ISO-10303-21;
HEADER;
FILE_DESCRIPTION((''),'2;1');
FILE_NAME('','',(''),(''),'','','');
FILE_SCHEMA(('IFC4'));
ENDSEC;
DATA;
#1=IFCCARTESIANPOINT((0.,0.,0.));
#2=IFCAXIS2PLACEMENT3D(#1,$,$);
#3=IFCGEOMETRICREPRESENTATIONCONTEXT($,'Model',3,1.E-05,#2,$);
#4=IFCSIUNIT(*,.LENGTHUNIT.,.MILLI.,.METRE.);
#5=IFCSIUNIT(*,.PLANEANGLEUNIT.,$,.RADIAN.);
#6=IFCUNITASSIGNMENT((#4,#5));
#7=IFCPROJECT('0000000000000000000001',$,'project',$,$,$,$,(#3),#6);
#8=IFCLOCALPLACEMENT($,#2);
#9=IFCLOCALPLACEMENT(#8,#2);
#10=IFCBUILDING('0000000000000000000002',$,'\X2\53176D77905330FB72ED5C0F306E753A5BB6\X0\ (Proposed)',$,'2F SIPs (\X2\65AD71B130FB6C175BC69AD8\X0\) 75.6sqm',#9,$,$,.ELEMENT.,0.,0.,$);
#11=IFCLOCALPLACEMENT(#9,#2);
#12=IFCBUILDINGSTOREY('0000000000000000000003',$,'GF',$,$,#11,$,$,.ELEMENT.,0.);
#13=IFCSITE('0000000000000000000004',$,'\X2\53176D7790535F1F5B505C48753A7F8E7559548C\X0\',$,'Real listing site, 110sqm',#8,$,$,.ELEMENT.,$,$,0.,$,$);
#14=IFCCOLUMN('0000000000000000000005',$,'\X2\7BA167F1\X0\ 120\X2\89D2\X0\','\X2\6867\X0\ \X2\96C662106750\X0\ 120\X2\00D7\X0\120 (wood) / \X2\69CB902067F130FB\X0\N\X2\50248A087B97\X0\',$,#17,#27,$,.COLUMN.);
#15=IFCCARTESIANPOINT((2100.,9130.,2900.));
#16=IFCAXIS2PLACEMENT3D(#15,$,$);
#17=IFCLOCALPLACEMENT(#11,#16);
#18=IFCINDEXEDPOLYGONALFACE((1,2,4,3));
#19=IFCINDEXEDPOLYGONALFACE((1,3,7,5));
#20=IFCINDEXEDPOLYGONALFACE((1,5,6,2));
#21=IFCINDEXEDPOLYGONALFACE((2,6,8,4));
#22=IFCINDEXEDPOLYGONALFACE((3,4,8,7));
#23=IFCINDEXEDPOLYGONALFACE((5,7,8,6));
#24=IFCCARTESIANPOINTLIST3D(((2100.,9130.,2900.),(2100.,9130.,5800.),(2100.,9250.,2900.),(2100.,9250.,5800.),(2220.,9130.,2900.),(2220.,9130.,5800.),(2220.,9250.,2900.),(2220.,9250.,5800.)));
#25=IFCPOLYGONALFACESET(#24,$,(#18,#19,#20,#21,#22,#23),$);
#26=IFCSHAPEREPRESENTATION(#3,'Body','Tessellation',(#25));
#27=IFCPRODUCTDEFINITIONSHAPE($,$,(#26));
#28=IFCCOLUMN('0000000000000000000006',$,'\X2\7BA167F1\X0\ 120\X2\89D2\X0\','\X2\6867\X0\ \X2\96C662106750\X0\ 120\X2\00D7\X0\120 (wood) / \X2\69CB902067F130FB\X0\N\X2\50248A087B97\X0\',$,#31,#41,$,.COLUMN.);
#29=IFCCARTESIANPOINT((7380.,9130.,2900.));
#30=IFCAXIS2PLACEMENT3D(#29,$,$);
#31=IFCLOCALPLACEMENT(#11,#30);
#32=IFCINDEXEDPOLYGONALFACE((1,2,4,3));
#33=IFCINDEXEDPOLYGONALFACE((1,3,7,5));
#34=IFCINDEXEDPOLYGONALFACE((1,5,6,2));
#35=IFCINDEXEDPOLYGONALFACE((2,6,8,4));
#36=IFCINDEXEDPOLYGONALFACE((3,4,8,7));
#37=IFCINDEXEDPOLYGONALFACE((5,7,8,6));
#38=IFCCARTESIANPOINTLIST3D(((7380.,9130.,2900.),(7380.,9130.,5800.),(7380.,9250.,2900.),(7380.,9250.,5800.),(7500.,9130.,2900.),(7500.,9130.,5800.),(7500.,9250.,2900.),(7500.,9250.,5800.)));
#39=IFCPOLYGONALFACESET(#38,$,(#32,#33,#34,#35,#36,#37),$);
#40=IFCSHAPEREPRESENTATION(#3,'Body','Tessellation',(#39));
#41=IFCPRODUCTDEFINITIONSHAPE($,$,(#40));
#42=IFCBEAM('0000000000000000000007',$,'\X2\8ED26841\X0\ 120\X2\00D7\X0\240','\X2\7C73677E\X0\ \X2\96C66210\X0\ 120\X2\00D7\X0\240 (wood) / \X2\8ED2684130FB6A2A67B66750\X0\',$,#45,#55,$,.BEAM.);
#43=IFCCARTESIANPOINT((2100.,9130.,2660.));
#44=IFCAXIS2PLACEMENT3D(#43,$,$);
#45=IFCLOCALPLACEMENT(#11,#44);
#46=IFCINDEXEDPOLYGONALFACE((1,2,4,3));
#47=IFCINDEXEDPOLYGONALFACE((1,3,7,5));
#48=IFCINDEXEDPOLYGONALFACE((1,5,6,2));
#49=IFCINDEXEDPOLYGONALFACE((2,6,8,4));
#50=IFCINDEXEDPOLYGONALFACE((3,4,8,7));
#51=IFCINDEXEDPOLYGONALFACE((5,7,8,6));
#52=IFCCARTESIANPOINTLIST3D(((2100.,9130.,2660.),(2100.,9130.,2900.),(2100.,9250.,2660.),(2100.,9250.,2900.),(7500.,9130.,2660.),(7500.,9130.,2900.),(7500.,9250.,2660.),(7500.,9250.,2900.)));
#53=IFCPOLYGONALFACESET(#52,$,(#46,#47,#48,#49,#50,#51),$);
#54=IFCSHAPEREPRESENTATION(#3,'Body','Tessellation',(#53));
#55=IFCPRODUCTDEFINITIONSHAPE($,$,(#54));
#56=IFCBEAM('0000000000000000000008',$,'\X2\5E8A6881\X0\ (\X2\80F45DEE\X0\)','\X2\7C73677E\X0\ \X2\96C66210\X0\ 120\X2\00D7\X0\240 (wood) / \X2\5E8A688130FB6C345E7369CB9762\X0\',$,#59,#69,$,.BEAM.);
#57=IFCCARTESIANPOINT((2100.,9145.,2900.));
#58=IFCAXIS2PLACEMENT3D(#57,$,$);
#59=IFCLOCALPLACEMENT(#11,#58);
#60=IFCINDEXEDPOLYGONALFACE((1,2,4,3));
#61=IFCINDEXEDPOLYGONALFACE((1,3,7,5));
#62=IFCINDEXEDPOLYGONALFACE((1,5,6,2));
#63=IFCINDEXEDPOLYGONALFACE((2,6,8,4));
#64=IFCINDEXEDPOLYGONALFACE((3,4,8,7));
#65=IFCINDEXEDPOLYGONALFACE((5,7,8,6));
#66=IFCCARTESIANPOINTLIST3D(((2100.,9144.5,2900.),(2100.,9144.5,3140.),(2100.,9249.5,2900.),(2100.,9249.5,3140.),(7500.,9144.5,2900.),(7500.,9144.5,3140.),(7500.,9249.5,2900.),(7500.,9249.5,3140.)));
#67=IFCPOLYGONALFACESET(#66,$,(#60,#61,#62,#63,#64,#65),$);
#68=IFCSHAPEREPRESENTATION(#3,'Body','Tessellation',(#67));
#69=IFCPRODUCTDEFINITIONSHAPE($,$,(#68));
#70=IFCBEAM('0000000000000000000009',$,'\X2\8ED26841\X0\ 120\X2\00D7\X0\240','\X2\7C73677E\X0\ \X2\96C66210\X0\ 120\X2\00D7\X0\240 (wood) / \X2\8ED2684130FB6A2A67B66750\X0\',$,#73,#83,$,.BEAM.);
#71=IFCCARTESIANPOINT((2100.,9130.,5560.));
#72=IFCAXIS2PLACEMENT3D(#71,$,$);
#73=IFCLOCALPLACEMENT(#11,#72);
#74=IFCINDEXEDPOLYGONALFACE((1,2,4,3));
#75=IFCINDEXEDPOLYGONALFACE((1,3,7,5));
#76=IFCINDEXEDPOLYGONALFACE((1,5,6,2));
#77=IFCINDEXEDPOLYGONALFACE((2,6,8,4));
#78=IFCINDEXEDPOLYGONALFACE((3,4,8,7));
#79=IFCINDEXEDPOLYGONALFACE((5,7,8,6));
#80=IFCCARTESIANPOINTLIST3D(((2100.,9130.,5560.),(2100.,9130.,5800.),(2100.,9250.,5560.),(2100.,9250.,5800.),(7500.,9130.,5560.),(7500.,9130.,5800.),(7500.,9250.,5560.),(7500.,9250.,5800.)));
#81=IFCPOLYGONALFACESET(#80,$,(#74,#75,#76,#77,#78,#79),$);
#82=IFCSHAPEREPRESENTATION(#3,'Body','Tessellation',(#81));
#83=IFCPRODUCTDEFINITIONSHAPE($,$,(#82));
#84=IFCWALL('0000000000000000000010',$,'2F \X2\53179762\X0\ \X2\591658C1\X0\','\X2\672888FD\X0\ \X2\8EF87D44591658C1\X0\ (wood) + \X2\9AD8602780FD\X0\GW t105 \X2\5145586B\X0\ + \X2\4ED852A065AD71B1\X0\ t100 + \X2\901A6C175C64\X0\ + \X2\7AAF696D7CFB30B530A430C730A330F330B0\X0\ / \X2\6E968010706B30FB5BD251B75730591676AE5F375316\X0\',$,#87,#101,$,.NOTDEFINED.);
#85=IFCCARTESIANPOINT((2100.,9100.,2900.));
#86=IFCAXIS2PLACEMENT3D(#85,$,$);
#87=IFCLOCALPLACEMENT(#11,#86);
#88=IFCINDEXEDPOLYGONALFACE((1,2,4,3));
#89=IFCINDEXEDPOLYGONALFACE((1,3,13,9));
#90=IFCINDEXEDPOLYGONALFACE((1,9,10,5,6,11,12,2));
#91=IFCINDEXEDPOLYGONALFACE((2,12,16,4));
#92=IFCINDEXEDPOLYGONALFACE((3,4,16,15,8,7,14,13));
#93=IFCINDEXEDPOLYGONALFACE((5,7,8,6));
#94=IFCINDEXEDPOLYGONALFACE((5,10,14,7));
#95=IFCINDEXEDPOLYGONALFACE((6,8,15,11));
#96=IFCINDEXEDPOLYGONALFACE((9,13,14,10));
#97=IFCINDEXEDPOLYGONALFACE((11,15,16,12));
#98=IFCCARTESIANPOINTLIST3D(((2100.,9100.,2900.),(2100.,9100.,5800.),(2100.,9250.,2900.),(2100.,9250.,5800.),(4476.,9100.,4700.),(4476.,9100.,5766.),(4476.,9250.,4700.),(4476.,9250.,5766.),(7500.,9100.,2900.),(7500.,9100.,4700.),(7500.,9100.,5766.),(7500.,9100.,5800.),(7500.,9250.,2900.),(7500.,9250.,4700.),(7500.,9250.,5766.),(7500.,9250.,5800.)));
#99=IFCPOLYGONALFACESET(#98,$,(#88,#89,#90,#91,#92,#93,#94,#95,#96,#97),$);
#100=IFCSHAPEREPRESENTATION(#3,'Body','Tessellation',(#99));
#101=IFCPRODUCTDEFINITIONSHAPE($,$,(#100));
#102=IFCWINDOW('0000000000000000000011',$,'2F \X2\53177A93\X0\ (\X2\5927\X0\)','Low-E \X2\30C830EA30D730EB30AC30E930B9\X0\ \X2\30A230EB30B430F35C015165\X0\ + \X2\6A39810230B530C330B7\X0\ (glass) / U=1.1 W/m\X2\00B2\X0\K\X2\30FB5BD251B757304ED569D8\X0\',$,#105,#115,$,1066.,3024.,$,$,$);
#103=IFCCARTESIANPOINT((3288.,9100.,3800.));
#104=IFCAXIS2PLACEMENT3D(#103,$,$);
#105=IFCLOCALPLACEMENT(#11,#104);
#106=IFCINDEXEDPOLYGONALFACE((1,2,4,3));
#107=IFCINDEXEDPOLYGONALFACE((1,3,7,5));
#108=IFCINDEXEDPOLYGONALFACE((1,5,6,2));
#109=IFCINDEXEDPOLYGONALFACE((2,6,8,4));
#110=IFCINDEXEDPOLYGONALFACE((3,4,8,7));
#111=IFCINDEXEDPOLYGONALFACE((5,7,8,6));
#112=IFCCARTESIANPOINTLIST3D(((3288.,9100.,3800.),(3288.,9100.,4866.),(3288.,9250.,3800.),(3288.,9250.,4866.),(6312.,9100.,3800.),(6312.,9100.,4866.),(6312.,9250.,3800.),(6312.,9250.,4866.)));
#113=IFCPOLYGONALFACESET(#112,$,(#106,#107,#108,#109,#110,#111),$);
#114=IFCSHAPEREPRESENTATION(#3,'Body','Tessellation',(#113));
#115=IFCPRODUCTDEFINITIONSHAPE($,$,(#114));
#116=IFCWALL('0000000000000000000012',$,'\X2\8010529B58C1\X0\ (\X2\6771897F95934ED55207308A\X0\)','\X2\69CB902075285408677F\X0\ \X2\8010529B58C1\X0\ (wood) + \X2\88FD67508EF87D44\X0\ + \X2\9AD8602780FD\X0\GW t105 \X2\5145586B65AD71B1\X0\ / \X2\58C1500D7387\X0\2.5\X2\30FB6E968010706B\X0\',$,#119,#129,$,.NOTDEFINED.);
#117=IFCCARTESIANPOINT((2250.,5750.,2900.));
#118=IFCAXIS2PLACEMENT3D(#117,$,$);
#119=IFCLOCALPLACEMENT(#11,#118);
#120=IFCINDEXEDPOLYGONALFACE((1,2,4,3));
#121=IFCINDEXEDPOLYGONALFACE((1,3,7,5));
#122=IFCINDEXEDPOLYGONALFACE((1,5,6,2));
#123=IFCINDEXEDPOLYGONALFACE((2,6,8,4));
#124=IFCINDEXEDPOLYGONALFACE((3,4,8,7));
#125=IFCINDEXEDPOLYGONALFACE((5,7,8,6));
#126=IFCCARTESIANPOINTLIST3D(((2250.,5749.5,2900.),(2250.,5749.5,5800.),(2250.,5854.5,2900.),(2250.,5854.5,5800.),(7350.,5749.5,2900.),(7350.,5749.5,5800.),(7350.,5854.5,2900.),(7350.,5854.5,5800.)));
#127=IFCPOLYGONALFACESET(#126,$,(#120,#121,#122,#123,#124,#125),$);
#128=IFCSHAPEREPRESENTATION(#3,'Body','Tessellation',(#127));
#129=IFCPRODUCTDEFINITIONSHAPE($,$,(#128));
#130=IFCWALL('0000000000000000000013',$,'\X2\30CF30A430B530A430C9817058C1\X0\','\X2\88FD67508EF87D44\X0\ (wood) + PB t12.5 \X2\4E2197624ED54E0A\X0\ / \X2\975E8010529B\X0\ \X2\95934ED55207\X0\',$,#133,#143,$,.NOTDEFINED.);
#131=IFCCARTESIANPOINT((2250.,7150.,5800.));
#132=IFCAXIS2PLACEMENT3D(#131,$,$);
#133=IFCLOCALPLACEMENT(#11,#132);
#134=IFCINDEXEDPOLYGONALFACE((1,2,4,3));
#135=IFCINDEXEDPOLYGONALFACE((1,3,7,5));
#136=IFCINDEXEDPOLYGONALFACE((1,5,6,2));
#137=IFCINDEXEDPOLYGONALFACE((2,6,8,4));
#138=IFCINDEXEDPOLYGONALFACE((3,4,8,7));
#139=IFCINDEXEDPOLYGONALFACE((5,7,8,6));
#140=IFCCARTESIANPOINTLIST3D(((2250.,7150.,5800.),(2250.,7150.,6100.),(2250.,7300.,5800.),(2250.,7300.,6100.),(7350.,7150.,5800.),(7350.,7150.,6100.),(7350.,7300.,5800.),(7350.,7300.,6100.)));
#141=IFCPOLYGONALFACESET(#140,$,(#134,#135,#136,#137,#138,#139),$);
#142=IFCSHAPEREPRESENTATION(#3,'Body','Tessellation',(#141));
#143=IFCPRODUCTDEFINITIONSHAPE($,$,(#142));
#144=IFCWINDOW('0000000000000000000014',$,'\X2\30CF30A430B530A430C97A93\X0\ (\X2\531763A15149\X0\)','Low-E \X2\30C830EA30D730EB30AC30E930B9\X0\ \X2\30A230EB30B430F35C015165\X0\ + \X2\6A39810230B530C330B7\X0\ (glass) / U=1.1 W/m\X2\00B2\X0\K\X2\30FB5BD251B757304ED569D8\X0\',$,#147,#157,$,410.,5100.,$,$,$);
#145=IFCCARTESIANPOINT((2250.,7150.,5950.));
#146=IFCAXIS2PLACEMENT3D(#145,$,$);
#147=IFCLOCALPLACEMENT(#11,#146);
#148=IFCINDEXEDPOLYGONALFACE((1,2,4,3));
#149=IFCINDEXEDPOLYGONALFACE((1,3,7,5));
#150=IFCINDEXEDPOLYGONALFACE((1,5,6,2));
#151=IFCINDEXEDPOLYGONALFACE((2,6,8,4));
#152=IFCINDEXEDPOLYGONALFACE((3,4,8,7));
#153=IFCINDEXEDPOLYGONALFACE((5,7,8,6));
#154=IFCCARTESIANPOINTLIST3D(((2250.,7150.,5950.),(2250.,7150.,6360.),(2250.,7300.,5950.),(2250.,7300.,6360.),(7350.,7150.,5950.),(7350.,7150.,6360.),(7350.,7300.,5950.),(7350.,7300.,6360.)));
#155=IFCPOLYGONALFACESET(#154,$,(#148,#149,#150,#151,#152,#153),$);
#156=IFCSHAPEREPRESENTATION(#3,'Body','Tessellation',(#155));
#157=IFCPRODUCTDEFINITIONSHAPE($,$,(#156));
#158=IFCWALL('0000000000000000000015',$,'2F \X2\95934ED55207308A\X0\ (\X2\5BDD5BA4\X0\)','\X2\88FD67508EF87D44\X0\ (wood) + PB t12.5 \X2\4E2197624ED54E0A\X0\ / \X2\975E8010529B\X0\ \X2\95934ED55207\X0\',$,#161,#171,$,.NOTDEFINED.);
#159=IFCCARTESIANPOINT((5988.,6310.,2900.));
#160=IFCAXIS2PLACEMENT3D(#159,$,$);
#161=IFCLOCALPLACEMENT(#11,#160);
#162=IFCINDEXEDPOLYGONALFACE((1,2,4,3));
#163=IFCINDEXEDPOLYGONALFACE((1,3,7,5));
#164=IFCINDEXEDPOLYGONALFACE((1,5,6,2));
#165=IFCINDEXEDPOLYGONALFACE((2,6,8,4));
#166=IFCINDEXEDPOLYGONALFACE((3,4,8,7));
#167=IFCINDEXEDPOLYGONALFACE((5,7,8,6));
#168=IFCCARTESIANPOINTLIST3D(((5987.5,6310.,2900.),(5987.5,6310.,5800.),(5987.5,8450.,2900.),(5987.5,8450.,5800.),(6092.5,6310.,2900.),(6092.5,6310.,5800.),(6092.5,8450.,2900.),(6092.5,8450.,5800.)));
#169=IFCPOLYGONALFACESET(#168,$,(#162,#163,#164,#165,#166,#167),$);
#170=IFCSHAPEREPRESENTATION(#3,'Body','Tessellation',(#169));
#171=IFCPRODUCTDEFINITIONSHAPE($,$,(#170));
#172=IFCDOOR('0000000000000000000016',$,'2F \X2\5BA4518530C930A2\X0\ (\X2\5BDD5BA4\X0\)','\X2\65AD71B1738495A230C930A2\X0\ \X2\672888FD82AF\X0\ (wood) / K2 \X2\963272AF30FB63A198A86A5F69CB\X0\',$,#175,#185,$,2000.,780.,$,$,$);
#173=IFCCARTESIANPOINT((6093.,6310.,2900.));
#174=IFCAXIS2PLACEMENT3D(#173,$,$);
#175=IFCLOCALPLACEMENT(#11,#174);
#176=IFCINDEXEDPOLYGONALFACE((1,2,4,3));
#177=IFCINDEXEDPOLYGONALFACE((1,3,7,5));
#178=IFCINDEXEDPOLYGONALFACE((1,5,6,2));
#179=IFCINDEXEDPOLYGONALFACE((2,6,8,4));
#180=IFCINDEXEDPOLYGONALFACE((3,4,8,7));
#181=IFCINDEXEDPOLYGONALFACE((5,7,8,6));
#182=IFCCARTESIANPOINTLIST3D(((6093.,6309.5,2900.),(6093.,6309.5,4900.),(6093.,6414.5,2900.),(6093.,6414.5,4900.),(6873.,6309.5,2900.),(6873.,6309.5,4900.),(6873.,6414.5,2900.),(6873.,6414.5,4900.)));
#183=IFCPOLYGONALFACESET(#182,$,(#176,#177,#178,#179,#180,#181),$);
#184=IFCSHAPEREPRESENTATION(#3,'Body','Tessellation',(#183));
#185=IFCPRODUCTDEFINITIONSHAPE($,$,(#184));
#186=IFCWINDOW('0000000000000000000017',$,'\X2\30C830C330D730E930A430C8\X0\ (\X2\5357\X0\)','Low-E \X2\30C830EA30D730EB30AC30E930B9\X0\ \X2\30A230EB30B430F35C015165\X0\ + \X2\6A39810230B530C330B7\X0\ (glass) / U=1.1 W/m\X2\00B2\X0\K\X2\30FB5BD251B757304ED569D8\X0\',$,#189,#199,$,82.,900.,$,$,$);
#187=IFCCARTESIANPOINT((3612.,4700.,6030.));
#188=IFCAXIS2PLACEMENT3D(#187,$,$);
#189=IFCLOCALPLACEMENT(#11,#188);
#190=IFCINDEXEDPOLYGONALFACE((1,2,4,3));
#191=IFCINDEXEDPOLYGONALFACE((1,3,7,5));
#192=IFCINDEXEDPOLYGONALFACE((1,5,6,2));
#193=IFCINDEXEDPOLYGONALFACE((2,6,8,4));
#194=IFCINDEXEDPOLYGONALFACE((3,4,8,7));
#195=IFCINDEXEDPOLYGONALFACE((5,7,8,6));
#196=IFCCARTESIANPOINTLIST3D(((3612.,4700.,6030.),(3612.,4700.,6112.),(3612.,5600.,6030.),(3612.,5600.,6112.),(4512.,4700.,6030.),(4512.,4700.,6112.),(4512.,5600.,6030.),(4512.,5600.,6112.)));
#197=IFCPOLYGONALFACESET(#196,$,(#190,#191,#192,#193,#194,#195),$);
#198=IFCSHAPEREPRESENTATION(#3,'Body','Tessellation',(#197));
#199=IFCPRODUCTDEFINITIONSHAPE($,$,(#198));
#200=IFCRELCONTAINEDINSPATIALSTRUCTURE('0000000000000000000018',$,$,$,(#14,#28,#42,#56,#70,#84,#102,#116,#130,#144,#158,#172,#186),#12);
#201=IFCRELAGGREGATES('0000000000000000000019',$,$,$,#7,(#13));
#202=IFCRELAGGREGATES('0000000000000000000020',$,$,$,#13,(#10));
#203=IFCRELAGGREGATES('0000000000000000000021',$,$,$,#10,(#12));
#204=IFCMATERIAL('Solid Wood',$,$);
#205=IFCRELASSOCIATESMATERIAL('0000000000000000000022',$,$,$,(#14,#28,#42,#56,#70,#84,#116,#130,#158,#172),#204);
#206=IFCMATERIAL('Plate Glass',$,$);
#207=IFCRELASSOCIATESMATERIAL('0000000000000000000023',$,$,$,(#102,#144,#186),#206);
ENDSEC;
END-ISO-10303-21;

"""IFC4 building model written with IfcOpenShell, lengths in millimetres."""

from ifc_helpers import new_model, si_unit, frame, frame_2d, origin, place, context, project, spatial, rectangle, extrude, material, element, fill, save


model = new_model("IFC4")

# Units and contexts
model_context = context("Model", 3, precision=1e-05, world=origin())
ifc_project = project(units=[si_unit("LENGTHUNIT", "METRE", prefix="MILLI"), si_unit("PLANEANGLEUNIT", "RADIAN")], contexts=[model_context])

# Site, building, storey
site_placement = place(None, origin())
site = spatial("IfcSite", under=ifc_project, at=site_placement, Name="北海道弟子屈町美留和", ObjectType="Real listing site, 110sqm", CompositionType="ELEMENT", RefElevation=0.0)
building_placement = place(site_placement, origin())
building = spatial("IfcBuilding", under=site, at=building_placement, Name="北海道・狭小の町家 (Proposed)", ObjectType="2F SIPs (断熱・気密高) 75.6sqm", CompositionType="ELEMENT", ElevationOfRefHeight=0.0, ElevationOfTerrain=0.0)
storey_placement = place(building_placement, origin())
storey = spatial("IfcBuildingStorey", under=building, at=storey_placement, Name="GF", CompositionType="ELEMENT", Elevation=0.0)

# Columns
ifc_material_1 = material(Name="Solid Wood")
column_1_placement = place(storey_placement, frame((2100.0, 9130.0, 2900.0)))
element("IfcColumn", 1, at=column_1_placement, inside=storey, material=ifc_material_1, Name="管柱 120角", Description="桧 集成材 120×120 (wood) / 構造柱・N値計算", PredefinedType="COLUMN", context=model_context, shape_type="SweptSolid", body=[
    extrude(rectangle(XDim=120.0, YDim=120.0, at=frame_2d((60.0, 60.0))), frame((2100.0, 9130.0, 2900.0)), (0.0, 0.0, 1.0), 2900.0),
])
column_2_placement = place(storey_placement, frame((7380.0, 9130.0, 2900.0)))
element("IfcColumn", 2, at=column_2_placement, inside=storey, material=ifc_material_1, Name="管柱 120角", Description="桧 集成材 120×120 (wood) / 構造柱・N値計算", PredefinedType="COLUMN", context=model_context, shape_type="SweptSolid", body=[
    extrude(rectangle(XDim=120.0, YDim=120.0, at=frame_2d((60.0, 60.0))), frame((7380.0, 9130.0, 2900.0)), (0.0, 0.0, 1.0), 2900.0),
])

# Beams
beam_1_placement = place(storey_placement, frame((2100.0, 9130.0, 2660.0)))
element("IfcBeam", 3, at=beam_1_placement, inside=storey, material=ifc_material_1, Name="軒桁 120×240", Description="米松 集成 120×240 (wood) / 軒桁・横架材", PredefinedType="BEAM", context=model_context, shape_type="SweptSolid", body=[
    extrude(rectangle(XDim=5400.0, YDim=120.0, at=frame_2d((2700.0, 60.0))), frame((2100.0, 9130.0, 2660.0)), (0.0, 0.0, 1.0), 240.0),
])
beam_2_placement = place(storey_placement, frame((2100.0, 9145.0, 2900.0)))
element("IfcBeam", 4, at=beam_2_placement, inside=storey, material=ifc_material_1, Name="床梁 (胴差)", Description="米松 集成 120×240 (wood) / 床梁・水平構面", PredefinedType="BEAM", context=model_context, shape_type="SweptSolid", body=[
    extrude(rectangle(XDim=5400.0, YDim=105.0, at=frame_2d((2700.0, 52.0))), frame((2100.0, 9145.0, 2900.0)), (0.0, 0.0, 1.0), 240.0),
])
beam_3_placement = place(storey_placement, frame((2100.0, 9130.0, 5560.0)))
element("IfcBeam", 5, at=beam_3_placement, inside=storey, material=ifc_material_1, Name="軒桁 120×240", Description="米松 集成 120×240 (wood) / 軒桁・横架材", PredefinedType="BEAM", context=model_context, shape_type="SweptSolid", body=[
    extrude(rectangle(XDim=5400.0, YDim=120.0, at=frame_2d((2700.0, 60.0))), frame((2100.0, 9130.0, 5560.0)), (0.0, 0.0, 1.0), 240.0),
])

# Wall, opening, window
wall_1_placement = place(storey_placement, frame((2100.0, 9100.0, 2900.0)))
wall_1 = element("IfcWall", 6, at=wall_1_placement, inside=storey, material=ifc_material_1, Name="2F 北面 外壁", Description="木製 軸組外壁 (wood) + 高性能GW t105 充填 + 付加断熱 t100 + 通気層 + 窯業系サイディング / 準耐火・寒冷地外皮強化", PredefinedType="NOTDEFINED", context=model_context, shape_type="SweptSolid", body=[
    extrude(rectangle(XDim=5400.0, YDim=150.0, at=frame_2d((2700.0, 75.0))), frame((2100.0, 9100.0, 2900.0)), (0.0, 0.0, 1.0), 2900.0),
])
opening_1_placement = place(storey_placement, frame((3288.0, 9100.0, 3800.0)))
opening_1 = element("IfcOpeningElement", 7, at=opening_1_placement, cuts=wall_1, PredefinedType="NOTDEFINED", context=model_context, shape_type="SweptSolid", body=[
    extrude(rectangle(XDim=3024.0, YDim=150.0, at=frame_2d((1512.0, 75.0))), frame((3288.0, 9100.0, 3800.0)), (0.0, 0.0, 1.0), 1066.0),
])
ifc_material_2 = material(Name="Plate Glass")
window_1_placement = place(storey_placement, frame((3288.0, 9100.0, 3800.0)))
window_1 = element("IfcWindow", 8, at=window_1_placement, inside=storey, material=ifc_material_2, Name="2F 北窓 (大)", Description="Low-E トリプルガラス アルゴン封入 + 樹脂サッシ (glass) / U=1.1 W/m²K・寒冷地仕様", OverallHeight=1066.0, OverallWidth=3024.0, context=model_context, shape_type="SweptSolid", body=[
    extrude(rectangle(XDim=3024.0, YDim=150.0, at=frame_2d((1512.0, 75.0))), frame((3288.0, 9100.0, 3800.0)), (0.0, 0.0, 1.0), 1066.0),
])
fill(opening_1, window_1)

# Wall
wall_2_placement = place(storey_placement, frame((2250.0, 5750.0, 2900.0)))
element("IfcWall", 9, at=wall_2_placement, inside=storey, material=ifc_material_1, Name="耐力壁 (東西間仕切り)", Description="構造用合板 耐力壁 (wood) + 製材軸組 + 高性能GW t105 充填断熱 / 壁倍率2.5・準耐火", PredefinedType="NOTDEFINED", context=model_context, shape_type="SweptSolid", body=[
    extrude(rectangle(XDim=5100.0, YDim=105.0, at=frame_2d((2550.0, 52.0))), frame((2250.0, 5750.0, 2900.0)), (0.0, 0.0, 1.0), 2900.0),
])

# Wall, opening, window
wall_3_placement = place(storey_placement, frame((2250.0, 7150.0, 5800.0)))
wall_3 = element("IfcWall", 10, at=wall_3_placement, inside=storey, material=ifc_material_1, Name="ハイサイド腰壁", Description="製材軸組 (wood) + PB t12.5 両面仕上 / 非耐力 間仕切", PredefinedType="NOTDEFINED", context=model_context, shape_type="SweptSolid", body=[
    extrude(rectangle(XDim=5100.0, YDim=150.0, at=frame_2d((2550.0, 75.0))), frame((2250.0, 7150.0, 5800.0)), (0.0, 0.0, 1.0), 700.0),
])
opening_2_placement = place(storey_placement, frame((2250.0, 7150.0, 5950.0)))
opening_2 = element("IfcOpeningElement", 11, at=opening_2_placement, cuts=wall_3, PredefinedType="NOTDEFINED", context=model_context, shape_type="SweptSolid", body=[
    extrude(rectangle(XDim=5100.0, YDim=150.0, at=frame_2d((2550.0, 75.0))), frame((2250.0, 7150.0, 5950.0)), (0.0, 0.0, 1.0), 410.0),
])
window_2_placement = place(storey_placement, frame((2250.0, 7150.0, 5950.0)))
window_2 = element("IfcWindow", 12, at=window_2_placement, inside=storey, material=ifc_material_2, Name="ハイサイド窓 (北採光)", Description="Low-E トリプルガラス アルゴン封入 + 樹脂サッシ (glass) / U=1.1 W/m²K・寒冷地仕様", OverallHeight=410.0, OverallWidth=5100.0, context=model_context, shape_type="SweptSolid", body=[
    extrude(rectangle(XDim=5100.0, YDim=150.0, at=frame_2d((2550.0, 75.0))), frame((2250.0, 7150.0, 5950.0)), (0.0, 0.0, 1.0), 410.0),
])
fill(opening_2, window_2)

# Wall
wall_4_placement = place(storey_placement, frame((5988.0, 6310.0, 2900.0)))
element("IfcWall", 13, at=wall_4_placement, inside=storey, material=ifc_material_1, Name="2F 間仕切り (寝室)", Description="製材軸組 (wood) + PB t12.5 両面仕上 / 非耐力 間仕切", PredefinedType="NOTDEFINED", context=model_context, shape_type="SweptSolid", body=[
    extrude(rectangle(XDim=105.0, YDim=2140.0, at=frame_2d((52.0, 1070.0))), frame((5988.0, 6310.0, 2900.0)), (0.0, 0.0, 1.0), 2900.0),
])

# Door
door_placement = place(storey_placement, frame((6093.0, 6310.0, 2900.0)))
element("IfcDoor", 14, at=door_placement, inside=storey, material=ifc_material_1, Name="2F 室内ドア (寝室)", Description="断熱玄関ドア 木製芯 (wood) / K2 防犯・採風機構", OverallHeight=2000.0, OverallWidth=780.0, context=model_context, shape_type="SweptSolid", body=[
    extrude(rectangle(XDim=780.0, YDim=105.0, at=frame_2d((390.0, 52.0))), frame((6093.0, 6310.0, 2900.0)), (0.0, 0.0, 1.0), 2000.0),
])

# Window
window_3_placement = place(storey_placement, frame((3612.0, 4700.0, 6030.0)))
element("IfcWindow", 15, at=window_3_placement, inside=storey, material=ifc_material_2, Name="トップライト (南)", Description="Low-E トリプルガラス アルゴン封入 + 樹脂サッシ (glass) / U=1.1 W/m²K・寒冷地仕様", OverallHeight=82.0, OverallWidth=900.0, context=model_context, shape_type="SweptSolid", body=[
    extrude(rectangle(XDim=900.0, YDim=900.0, at=frame_2d((450.0, 450.0))), frame((3612.0, 4700.0, 6030.0)), (0.0, 0.0, 1.0), 82.0),
])

save(model, "model.ifc")
